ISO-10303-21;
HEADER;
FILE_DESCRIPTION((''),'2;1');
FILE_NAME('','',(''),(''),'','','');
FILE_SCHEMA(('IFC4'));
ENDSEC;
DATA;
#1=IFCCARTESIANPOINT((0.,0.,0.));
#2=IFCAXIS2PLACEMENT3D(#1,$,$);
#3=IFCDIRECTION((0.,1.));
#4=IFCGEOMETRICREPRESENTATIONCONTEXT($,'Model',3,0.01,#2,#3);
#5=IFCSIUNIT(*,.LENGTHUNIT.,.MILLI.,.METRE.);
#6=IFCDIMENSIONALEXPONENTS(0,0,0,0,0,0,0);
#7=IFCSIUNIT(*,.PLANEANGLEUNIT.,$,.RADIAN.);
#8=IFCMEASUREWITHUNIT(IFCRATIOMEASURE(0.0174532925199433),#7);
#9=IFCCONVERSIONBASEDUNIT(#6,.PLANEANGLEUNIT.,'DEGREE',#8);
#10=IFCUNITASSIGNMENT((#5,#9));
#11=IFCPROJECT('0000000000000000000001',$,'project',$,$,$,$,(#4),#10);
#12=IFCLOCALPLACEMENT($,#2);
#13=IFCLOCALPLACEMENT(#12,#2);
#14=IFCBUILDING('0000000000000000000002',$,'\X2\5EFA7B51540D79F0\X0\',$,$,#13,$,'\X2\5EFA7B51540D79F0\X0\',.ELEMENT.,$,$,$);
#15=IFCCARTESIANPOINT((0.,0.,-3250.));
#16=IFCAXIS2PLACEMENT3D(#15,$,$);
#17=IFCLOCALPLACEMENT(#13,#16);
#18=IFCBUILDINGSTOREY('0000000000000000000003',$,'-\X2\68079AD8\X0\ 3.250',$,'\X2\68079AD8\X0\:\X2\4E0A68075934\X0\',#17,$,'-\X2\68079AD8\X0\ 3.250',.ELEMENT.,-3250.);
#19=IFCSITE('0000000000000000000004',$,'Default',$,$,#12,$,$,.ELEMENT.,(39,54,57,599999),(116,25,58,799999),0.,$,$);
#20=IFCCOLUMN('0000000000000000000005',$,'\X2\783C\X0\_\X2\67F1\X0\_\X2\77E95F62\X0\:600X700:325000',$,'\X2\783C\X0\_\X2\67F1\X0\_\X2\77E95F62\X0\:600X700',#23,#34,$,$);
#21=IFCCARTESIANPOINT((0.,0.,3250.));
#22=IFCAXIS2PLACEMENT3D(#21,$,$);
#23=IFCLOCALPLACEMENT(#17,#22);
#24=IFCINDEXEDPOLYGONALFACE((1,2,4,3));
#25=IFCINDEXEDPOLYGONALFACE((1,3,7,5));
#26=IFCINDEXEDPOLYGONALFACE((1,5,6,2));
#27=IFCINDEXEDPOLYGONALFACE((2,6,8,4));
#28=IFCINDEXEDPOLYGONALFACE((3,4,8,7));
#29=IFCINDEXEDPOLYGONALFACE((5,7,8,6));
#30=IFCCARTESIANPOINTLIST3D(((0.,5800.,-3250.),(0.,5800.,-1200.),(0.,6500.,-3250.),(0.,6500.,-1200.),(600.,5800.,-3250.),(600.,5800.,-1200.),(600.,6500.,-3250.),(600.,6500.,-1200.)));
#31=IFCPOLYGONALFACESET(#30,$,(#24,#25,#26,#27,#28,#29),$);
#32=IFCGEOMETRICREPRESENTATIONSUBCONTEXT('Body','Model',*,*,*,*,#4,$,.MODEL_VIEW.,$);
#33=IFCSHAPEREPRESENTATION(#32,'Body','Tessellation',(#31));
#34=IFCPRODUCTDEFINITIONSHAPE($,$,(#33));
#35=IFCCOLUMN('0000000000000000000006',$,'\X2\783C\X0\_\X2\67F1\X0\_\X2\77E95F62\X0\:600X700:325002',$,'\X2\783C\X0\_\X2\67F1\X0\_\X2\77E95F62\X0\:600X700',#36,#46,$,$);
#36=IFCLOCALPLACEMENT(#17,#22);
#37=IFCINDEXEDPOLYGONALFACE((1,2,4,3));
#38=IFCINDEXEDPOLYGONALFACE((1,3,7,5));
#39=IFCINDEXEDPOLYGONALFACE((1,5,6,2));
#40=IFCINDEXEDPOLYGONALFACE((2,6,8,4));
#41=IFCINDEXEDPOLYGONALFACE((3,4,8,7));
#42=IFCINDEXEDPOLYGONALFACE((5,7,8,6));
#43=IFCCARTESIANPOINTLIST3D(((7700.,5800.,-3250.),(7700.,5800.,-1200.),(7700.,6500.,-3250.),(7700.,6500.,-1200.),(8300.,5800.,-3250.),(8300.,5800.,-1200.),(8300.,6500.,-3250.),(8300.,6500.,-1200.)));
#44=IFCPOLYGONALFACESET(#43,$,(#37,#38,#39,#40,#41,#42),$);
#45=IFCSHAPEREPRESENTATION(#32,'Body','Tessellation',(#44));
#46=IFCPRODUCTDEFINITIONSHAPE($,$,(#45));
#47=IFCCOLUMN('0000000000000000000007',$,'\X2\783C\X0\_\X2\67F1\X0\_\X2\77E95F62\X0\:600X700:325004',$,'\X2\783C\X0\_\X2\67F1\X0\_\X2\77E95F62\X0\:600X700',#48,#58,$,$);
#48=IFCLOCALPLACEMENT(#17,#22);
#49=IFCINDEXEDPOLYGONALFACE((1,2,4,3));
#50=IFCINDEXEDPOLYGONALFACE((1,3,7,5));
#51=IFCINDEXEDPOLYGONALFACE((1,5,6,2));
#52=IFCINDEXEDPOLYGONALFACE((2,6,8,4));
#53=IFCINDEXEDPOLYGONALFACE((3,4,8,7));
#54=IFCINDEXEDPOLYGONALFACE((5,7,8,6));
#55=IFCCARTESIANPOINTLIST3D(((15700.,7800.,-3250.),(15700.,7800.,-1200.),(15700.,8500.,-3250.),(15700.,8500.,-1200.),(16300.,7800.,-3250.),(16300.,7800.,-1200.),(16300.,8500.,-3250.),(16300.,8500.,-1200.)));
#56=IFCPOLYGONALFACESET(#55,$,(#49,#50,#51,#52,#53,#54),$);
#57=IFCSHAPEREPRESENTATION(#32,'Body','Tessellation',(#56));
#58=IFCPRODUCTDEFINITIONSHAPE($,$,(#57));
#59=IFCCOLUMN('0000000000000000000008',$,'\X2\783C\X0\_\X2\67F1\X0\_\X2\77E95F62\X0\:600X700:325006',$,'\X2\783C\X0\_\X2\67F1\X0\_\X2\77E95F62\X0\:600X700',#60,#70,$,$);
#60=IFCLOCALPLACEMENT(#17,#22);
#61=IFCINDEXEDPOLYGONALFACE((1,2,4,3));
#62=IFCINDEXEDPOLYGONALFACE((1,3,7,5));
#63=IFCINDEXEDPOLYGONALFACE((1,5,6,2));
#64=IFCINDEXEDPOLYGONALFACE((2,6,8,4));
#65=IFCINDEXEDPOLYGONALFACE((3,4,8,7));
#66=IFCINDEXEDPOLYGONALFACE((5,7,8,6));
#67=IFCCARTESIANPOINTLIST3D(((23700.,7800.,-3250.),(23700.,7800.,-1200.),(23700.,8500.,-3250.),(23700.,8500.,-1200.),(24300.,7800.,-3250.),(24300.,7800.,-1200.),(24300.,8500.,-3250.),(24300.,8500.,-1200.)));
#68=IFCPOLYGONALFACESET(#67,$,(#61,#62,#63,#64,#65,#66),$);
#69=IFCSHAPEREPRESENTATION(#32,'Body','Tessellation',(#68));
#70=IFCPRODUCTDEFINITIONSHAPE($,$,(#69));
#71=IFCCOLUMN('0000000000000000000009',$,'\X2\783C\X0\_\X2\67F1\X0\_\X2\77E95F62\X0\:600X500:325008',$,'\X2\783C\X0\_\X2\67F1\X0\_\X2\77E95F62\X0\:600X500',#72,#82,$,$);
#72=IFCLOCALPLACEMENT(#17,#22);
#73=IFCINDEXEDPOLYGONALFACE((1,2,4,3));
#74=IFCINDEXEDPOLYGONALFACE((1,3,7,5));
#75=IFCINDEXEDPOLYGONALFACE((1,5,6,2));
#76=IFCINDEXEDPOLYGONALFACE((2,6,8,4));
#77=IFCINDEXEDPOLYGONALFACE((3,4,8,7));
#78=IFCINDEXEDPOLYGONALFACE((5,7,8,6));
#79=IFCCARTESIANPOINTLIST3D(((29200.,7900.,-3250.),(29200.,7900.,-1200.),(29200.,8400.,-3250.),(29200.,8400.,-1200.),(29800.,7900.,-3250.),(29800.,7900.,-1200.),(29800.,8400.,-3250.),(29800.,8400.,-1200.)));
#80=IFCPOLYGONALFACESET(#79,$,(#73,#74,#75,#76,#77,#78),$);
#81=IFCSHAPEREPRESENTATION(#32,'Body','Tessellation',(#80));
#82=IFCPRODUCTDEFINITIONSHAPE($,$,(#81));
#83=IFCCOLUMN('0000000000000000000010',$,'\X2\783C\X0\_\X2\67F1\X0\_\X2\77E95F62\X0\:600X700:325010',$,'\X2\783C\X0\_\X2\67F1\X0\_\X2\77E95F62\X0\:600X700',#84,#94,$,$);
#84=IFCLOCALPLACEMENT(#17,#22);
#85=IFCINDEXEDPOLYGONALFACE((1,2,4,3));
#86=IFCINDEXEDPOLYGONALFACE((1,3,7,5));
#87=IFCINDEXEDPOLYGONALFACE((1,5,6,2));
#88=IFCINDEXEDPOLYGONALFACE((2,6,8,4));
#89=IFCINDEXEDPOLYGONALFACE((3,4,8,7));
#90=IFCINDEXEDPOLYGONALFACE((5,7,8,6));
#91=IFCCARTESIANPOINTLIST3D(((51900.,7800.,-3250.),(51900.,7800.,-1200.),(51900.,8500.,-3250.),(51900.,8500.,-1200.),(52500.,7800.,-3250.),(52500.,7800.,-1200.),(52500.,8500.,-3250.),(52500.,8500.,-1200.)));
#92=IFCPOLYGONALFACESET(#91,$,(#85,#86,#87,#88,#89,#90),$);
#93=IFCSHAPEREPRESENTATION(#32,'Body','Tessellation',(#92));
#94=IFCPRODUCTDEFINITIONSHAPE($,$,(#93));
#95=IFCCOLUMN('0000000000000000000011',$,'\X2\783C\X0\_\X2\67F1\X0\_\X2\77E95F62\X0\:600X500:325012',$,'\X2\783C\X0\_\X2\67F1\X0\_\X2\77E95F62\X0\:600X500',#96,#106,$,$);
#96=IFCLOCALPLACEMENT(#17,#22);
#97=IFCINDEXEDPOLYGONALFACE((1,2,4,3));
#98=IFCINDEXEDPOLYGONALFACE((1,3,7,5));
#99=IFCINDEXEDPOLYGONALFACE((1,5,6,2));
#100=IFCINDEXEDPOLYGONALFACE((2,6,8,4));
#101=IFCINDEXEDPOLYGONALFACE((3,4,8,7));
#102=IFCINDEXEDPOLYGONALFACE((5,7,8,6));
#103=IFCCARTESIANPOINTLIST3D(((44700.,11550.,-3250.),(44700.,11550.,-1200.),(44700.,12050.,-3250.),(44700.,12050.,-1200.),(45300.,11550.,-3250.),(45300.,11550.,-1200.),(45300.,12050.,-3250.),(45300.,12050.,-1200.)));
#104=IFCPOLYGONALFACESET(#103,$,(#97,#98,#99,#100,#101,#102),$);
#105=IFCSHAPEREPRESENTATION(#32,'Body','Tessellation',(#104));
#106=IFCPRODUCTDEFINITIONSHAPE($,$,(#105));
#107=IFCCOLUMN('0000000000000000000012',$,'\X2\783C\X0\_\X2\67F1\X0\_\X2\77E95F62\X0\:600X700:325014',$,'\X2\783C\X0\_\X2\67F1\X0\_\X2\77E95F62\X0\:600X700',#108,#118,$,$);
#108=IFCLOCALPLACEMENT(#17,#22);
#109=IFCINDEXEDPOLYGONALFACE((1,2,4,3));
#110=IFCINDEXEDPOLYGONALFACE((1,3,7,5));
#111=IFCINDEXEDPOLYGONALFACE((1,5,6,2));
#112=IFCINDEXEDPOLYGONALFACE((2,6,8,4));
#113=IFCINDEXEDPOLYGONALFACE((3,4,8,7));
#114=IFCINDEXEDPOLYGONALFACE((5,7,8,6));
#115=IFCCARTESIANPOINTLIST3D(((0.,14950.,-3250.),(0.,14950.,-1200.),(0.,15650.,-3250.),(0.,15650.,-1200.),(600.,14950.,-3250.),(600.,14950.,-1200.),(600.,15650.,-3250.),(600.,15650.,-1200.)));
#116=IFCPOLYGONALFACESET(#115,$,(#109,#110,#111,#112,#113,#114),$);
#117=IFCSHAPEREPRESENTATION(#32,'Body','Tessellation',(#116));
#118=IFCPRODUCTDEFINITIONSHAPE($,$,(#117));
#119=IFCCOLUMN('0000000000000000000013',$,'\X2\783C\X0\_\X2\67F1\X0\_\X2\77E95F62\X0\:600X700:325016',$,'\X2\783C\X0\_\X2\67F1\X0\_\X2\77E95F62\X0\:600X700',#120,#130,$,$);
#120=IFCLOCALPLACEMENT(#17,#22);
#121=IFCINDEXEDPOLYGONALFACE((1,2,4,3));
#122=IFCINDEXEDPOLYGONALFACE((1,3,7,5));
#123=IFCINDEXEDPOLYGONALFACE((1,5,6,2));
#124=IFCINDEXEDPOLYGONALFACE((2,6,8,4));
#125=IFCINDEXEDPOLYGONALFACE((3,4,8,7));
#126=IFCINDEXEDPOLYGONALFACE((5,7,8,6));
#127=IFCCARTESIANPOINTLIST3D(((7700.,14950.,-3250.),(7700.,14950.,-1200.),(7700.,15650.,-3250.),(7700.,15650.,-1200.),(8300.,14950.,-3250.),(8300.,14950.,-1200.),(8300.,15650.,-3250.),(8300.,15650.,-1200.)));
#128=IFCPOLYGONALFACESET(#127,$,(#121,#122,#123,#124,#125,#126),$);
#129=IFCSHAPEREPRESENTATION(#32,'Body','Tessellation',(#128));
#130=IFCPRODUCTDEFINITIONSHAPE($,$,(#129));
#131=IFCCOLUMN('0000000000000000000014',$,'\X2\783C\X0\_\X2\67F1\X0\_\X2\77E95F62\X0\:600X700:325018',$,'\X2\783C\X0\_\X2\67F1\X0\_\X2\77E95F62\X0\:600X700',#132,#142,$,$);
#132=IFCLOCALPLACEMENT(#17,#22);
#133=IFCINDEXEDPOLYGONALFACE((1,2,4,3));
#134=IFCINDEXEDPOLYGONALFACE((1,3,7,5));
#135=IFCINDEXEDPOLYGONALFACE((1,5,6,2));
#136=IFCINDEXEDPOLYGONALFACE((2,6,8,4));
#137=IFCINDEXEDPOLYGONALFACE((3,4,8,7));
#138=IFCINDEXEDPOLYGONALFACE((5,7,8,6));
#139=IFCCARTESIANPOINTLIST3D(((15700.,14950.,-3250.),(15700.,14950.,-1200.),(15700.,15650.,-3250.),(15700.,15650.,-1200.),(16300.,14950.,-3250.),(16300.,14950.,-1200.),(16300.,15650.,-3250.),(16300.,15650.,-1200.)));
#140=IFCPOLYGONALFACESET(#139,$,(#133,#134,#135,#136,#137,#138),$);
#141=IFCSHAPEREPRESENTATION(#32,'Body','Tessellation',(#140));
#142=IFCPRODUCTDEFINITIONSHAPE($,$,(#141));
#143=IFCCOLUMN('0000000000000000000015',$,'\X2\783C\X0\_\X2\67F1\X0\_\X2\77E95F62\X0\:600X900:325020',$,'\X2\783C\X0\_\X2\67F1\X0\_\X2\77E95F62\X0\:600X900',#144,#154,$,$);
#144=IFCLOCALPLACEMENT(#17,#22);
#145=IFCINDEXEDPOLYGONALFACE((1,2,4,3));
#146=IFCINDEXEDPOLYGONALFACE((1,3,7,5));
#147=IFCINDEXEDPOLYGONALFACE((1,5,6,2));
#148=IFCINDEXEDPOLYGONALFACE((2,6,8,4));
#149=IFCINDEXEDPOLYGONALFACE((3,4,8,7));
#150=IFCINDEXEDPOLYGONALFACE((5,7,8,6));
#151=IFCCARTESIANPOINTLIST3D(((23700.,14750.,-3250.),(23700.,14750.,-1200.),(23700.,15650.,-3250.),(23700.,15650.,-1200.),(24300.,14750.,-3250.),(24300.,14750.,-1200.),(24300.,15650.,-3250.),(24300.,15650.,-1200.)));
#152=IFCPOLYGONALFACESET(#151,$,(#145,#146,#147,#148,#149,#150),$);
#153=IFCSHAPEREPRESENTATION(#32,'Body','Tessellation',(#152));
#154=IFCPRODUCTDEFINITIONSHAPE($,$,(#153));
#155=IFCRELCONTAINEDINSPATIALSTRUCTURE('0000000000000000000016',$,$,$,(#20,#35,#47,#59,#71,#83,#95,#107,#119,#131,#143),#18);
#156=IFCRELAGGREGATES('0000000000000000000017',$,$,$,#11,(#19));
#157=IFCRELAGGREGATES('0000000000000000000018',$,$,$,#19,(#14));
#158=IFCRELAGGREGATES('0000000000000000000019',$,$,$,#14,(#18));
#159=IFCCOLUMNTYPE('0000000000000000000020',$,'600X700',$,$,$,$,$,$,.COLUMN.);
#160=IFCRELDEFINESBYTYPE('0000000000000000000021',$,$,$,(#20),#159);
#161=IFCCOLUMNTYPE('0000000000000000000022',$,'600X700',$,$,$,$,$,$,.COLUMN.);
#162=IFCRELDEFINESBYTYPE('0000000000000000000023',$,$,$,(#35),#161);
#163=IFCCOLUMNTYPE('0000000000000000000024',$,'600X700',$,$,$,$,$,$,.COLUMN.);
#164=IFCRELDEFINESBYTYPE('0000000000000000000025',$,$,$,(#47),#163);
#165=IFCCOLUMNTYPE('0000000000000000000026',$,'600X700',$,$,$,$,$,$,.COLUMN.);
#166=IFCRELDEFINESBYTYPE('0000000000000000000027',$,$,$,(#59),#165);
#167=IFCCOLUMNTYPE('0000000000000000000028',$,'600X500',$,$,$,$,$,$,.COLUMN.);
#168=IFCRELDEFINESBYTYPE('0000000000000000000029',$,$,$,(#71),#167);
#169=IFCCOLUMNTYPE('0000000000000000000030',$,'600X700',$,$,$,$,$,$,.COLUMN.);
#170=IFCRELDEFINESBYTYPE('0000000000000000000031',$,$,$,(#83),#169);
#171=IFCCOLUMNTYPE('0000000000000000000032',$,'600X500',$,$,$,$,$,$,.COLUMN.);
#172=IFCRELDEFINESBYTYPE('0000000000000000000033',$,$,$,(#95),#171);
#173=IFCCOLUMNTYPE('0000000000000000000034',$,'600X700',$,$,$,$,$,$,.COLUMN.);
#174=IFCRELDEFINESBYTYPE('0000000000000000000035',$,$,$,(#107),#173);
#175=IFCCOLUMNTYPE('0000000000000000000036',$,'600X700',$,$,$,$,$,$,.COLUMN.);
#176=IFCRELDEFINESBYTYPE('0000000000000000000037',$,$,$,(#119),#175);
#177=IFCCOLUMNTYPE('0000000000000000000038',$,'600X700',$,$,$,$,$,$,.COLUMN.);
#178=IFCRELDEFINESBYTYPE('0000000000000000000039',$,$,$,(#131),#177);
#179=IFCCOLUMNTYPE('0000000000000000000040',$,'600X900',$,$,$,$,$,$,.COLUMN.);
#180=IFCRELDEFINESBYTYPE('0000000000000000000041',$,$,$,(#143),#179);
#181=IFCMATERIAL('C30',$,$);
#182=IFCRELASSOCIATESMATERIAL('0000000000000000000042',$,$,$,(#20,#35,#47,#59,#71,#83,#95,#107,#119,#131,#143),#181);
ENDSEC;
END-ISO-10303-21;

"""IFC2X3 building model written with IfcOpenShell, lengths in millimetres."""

from ifc_helpers import new_model, entity, si_unit, converted_unit, direction, frame, frame_2d, origin, origin_2d_with_axis, place, context, subcontext, project, spatial, rectangle, extrude, source, transform, mapped, material, type_object, type_shapes, element, save


model = new_model("IFC2X3")

# Units and contexts
model_context = context("Model", 3, precision=0.01, world=origin(), true_north=direction((0.0, 1.0)))
body_context = subcontext(model_context, "Body", "Model", "MODEL_VIEW")
ifc_project = project(units=[si_unit("LENGTHUNIT", "METRE", prefix="MILLI"), converted_unit("PLANEANGLEUNIT", "DEGREE", entity("IfcRatioMeasure", 0.0174532925199433), si_unit("PLANEANGLEUNIT", "RADIAN"), dimensions=[0, 0, 0, 0, 0, 0, 0])], contexts=[model_context])

# Site, building, storey
site_placement = place(None, origin())
site = spatial("IfcSite", under=ifc_project, at=site_placement, Name="Default", CompositionType="ELEMENT", RefLatitude=(39, 54, 57, 599999), RefLongitude=(116, 25, 58, 799999), RefElevation=0.0)
building_placement = place(site_placement, origin())
building = spatial("IfcBuilding", under=site, at=building_placement, Name="建筑名称", LongName="建筑名称", CompositionType="ELEMENT")
storey_placement = place(building_placement, frame((0.0, 0.0, -3250.0)))
storey = spatial("IfcBuildingStorey", under=building, at=storey_placement, Name="-标高 3.250", ObjectType="标高:上标头", LongName="-标高 3.250", CompositionType="ELEMENT", Elevation=-3250.0)

# Columns
ifc_material_1 = material(Name="C30")
column_type_1 = type_object("IfcColumnType", Name="600X700", PredefinedType="COLUMN")
shared_shape_1 = source(origin(), body_context, "Body", "SweptSolid", [
    extrude(rectangle(XDim=700.0, YDim=600.0, at=origin_2d_with_axis()), frame((300.0, 6150.0, -3250.0), z_axis=(0.0, 0.0, 1.0), x_axis=(0.0, -1.0, 0.0)), (0.0, 0.0, 1.0), 2050.0),
])
type_shapes(column_type_1, [shared_shape_1])
column_1_placement = place(storey_placement, frame((0.0, 0.0, 3250.0)))
element("IfcColumn", 1, at=column_1_placement, inside=storey, type_object=column_type_1, material=ifc_material_1, Name="砼_柱_矩形:600X700:325000", ObjectType="砼_柱_矩形:600X700", context=body_context, shape_type="MappedRepresentation", body=[
    mapped(shared_shape_1, transform((0.0, 0.0, 0.0), scale=1.0)),
])
column_type_2 = type_object("IfcColumnType", Name="600X700", PredefinedType="COLUMN")
shared_shape_2 = source(origin(), body_context, "Body", "SweptSolid", [
    extrude(rectangle(XDim=700.0, YDim=600.0, at=origin_2d_with_axis()), frame((8000.0, 6150.0, -3250.0), z_axis=(0.0, 0.0, 1.0), x_axis=(0.0, -1.0, 0.0)), (0.0, 0.0, 1.0), 2050.0),
])
type_shapes(column_type_2, [shared_shape_2])
column_2_placement = place(storey_placement, frame((0.0, 0.0, 3250.0)))
element("IfcColumn", 2, at=column_2_placement, inside=storey, type_object=column_type_2, material=ifc_material_1, Name="砼_柱_矩形:600X700:325002", ObjectType="砼_柱_矩形:600X700", context=body_context, shape_type="MappedRepresentation", body=[
    mapped(shared_shape_2, transform((0.0, 0.0, 0.0), scale=1.0)),
])
column_type_3 = type_object("IfcColumnType", Name="600X700", PredefinedType="COLUMN")
shared_shape_3 = source(origin(), body_context, "Body", "SweptSolid", [
    extrude(rectangle(XDim=700.0, YDim=600.0, at=frame_2d((0.0, 0.0), x_axis=(1.0, 0.0))), frame((16000.0, 8150.0, -3250.0), z_axis=(0.0, 0.0, 1.0), x_axis=(0.0, -1.0, 0.0)), (0.0, 0.0, 1.0), 2050.0),
])
type_shapes(column_type_3, [shared_shape_3])
column_3_placement = place(storey_placement, frame((0.0, 0.0, 3250.0)))
element("IfcColumn", 3, at=column_3_placement, inside=storey, type_object=column_type_3, material=ifc_material_1, Name="砼_柱_矩形:600X700:325004", ObjectType="砼_柱_矩形:600X700", context=body_context, shape_type="MappedRepresentation", body=[
    mapped(shared_shape_3, transform((0.0, 0.0, 0.0), scale=1.0)),
])
column_type_4 = type_object("IfcColumnType", Name="600X700", PredefinedType="COLUMN")
shared_shape_4 = source(origin(), body_context, "Body", "SweptSolid", [
    extrude(rectangle(XDim=700.0, YDim=600.0, at=origin_2d_with_axis()), frame((24000.0, 8150.0, -3250.0), z_axis=(0.0, 0.0, 1.0), x_axis=(0.0, -1.0, 0.0)), (0.0, 0.0, 1.0), 2050.0),
])
type_shapes(column_type_4, [shared_shape_4])
column_4_placement = place(storey_placement, frame((0.0, 0.0, 3250.0)))
element("IfcColumn", 4, at=column_4_placement, inside=storey, type_object=column_type_4, material=ifc_material_1, Name="砼_柱_矩形:600X700:325006", ObjectType="砼_柱_矩形:600X700", context=body_context, shape_type="MappedRepresentation", body=[
    mapped(shared_shape_4, transform((0.0, 0.0, 0.0), scale=1.0)),
])
column_type_5 = type_object("IfcColumnType", Name="600X500", PredefinedType="COLUMN")
shared_shape_5 = source(origin(), body_context, "Body", "SweptSolid", [
    extrude(rectangle(XDim=500.0, YDim=600.0, at=frame_2d((0.0, 0.0), x_axis=(1.0, 0.0))), frame((29500.0, 8150.0, -3250.0), z_axis=(0.0, 0.0, 1.0), x_axis=(0.0, -1.0, 0.0)), (0.0, 0.0, 1.0), 2050.0),
])
type_shapes(column_type_5, [shared_shape_5])
column_5_placement = place(storey_placement, frame((0.0, 0.0, 3250.0)))
element("IfcColumn", 5, at=column_5_placement, inside=storey, type_object=column_type_5, material=ifc_material_1, Name="砼_柱_矩形:600X500:325008", ObjectType="砼_柱_矩形:600X500", context=body_context, shape_type="MappedRepresentation", body=[
    mapped(shared_shape_5, transform((0.0, 0.0, 0.0), scale=1.0)),
])
column_type_6 = type_object("IfcColumnType", Name="600X700", PredefinedType="COLUMN")
shared_shape_6 = source(origin(), body_context, "Body", "SweptSolid", [
    extrude(rectangle(XDim=700.0, YDim=600.0, at=origin_2d_with_axis()), frame((52200.0, 8150.0, -3250.0), z_axis=(0.0, 0.0, 1.0), x_axis=(0.0, -1.0, 0.0)), (0.0, 0.0, 1.0), 2050.0),
])
type_shapes(column_type_6, [shared_shape_6])
column_6_placement = place(storey_placement, frame((0.0, 0.0, 3250.0)))
element("IfcColumn", 6, at=column_6_placement, inside=storey, type_object=column_type_6, material=ifc_material_1, Name="砼_柱_矩形:600X700:325010", ObjectType="砼_柱_矩形:600X700", context=body_context, shape_type="MappedRepresentation", body=[
    mapped(shared_shape_6, transform((0.0, 0.0, 0.0), scale=1.0)),
])
column_type_7 = type_object("IfcColumnType", Name="600X500", PredefinedType="COLUMN")
shared_shape_7 = source(origin(), body_context, "Body", "SweptSolid", [
    extrude(rectangle(XDim=500.0, YDim=600.0, at=origin_2d_with_axis()), frame((45000.0, 11800.0, -3250.0), z_axis=(0.0, 0.0, 1.0), x_axis=(0.0, -1.0, 0.0)), (0.0, 0.0, 1.0), 2050.0),
])
type_shapes(column_type_7, [shared_shape_7])
column_7_placement = place(storey_placement, frame((0.0, 0.0, 3250.0)))
element("IfcColumn", 7, at=column_7_placement, inside=storey, type_object=column_type_7, material=ifc_material_1, Name="砼_柱_矩形:600X500:325012", ObjectType="砼_柱_矩形:600X500", context=body_context, shape_type="MappedRepresentation", body=[
    mapped(shared_shape_7, transform((0.0, 0.0, 0.0), scale=1.0)),
])
column_type_8 = type_object("IfcColumnType", Name="600X700", PredefinedType="COLUMN")
shared_shape_8 = source(origin(), body_context, "Body", "SweptSolid", [
    extrude(rectangle(XDim=700.0, YDim=600.0, at=origin_2d_with_axis()), frame((300.0, 15300.0, -3250.0), z_axis=(0.0, 0.0, 1.0), x_axis=(0.0, -1.0, 0.0)), (0.0, 0.0, 1.0), 2050.0),
])
type_shapes(column_type_8, [shared_shape_8])
column_8_placement = place(storey_placement, frame((0.0, 0.0, 3250.0)))
element("IfcColumn", 8, at=column_8_placement, inside=storey, type_object=column_type_8, material=ifc_material_1, Name="砼_柱_矩形:600X700:325014", ObjectType="砼_柱_矩形:600X700", context=body_context, shape_type="MappedRepresentation", body=[
    mapped(shared_shape_8, transform((0.0, 0.0, 0.0), scale=1.0)),
])
column_type_9 = type_object("IfcColumnType", Name="600X700", PredefinedType="COLUMN")
shared_shape_9 = source(origin(), body_context, "Body", "SweptSolid", [
    extrude(rectangle(XDim=700.0, YDim=600.0, at=origin_2d_with_axis()), frame((8000.0, 15300.0, -3250.0), z_axis=(0.0, 0.0, 1.0), x_axis=(0.0, -1.0, 0.0)), (0.0, 0.0, 1.0), 2050.0),
])
type_shapes(column_type_9, [shared_shape_9])
column_9_placement = place(storey_placement, frame((0.0, 0.0, 3250.0)))
element("IfcColumn", 9, at=column_9_placement, inside=storey, type_object=column_type_9, material=ifc_material_1, Name="砼_柱_矩形:600X700:325016", ObjectType="砼_柱_矩形:600X700", context=body_context, shape_type="MappedRepresentation", body=[
    mapped(shared_shape_9, transform((0.0, 0.0, 0.0), scale=1.0)),
])
column_type_10 = type_object("IfcColumnType", Name="600X700", PredefinedType="COLUMN")
shared_shape_10 = source(origin(), body_context, "Body", "SweptSolid", [
    extrude(rectangle(XDim=700.0, YDim=600.0, at=frame_2d((0.0, 0.0), x_axis=(1.0, 0.0))), frame((16000.0, 15300.0, -3250.0), z_axis=(0.0, 0.0, 1.0), x_axis=(0.0, -1.0, 0.0)), (0.0, 0.0, 1.0), 2050.0),
])
type_shapes(column_type_10, [shared_shape_10])
column_10_placement = place(storey_placement, frame((0.0, 0.0, 3250.0)))
element("IfcColumn", 10, at=column_10_placement, inside=storey, type_object=column_type_10, material=ifc_material_1, Name="砼_柱_矩形:600X700:325018", ObjectType="砼_柱_矩形:600X700", context=body_context, shape_type="MappedRepresentation", body=[
    mapped(shared_shape_10, transform((0.0, 0.0, 0.0), scale=1.0)),
])
column_type_11 = type_object("IfcColumnType", Name="600X900", PredefinedType="COLUMN")
shared_shape_11 = source(origin(), body_context, "Body", "SweptSolid", [
    extrude(rectangle(XDim=900.0, YDim=600.0, at=origin_2d_with_axis()), frame((24000.0, 15200.0, -3250.0), z_axis=(0.0, 0.0, 1.0), x_axis=(0.0, -1.0, 0.0)), (0.0, 0.0, 1.0), 2050.0),
])
type_shapes(column_type_11, [shared_shape_11])
column_11_placement = place(storey_placement, frame((0.0, 0.0, 3250.0)))
element("IfcColumn", 11, at=column_11_placement, inside=storey, type_object=column_type_11, material=ifc_material_1, Name="砼_柱_矩形:600X900:325020", ObjectType="砼_柱_矩形:600X900", context=body_context, shape_type="MappedRepresentation", body=[
    mapped(shared_shape_11, transform((0.0, 0.0, 0.0), scale=1.0)),
])

save(model, "model.ifc")
